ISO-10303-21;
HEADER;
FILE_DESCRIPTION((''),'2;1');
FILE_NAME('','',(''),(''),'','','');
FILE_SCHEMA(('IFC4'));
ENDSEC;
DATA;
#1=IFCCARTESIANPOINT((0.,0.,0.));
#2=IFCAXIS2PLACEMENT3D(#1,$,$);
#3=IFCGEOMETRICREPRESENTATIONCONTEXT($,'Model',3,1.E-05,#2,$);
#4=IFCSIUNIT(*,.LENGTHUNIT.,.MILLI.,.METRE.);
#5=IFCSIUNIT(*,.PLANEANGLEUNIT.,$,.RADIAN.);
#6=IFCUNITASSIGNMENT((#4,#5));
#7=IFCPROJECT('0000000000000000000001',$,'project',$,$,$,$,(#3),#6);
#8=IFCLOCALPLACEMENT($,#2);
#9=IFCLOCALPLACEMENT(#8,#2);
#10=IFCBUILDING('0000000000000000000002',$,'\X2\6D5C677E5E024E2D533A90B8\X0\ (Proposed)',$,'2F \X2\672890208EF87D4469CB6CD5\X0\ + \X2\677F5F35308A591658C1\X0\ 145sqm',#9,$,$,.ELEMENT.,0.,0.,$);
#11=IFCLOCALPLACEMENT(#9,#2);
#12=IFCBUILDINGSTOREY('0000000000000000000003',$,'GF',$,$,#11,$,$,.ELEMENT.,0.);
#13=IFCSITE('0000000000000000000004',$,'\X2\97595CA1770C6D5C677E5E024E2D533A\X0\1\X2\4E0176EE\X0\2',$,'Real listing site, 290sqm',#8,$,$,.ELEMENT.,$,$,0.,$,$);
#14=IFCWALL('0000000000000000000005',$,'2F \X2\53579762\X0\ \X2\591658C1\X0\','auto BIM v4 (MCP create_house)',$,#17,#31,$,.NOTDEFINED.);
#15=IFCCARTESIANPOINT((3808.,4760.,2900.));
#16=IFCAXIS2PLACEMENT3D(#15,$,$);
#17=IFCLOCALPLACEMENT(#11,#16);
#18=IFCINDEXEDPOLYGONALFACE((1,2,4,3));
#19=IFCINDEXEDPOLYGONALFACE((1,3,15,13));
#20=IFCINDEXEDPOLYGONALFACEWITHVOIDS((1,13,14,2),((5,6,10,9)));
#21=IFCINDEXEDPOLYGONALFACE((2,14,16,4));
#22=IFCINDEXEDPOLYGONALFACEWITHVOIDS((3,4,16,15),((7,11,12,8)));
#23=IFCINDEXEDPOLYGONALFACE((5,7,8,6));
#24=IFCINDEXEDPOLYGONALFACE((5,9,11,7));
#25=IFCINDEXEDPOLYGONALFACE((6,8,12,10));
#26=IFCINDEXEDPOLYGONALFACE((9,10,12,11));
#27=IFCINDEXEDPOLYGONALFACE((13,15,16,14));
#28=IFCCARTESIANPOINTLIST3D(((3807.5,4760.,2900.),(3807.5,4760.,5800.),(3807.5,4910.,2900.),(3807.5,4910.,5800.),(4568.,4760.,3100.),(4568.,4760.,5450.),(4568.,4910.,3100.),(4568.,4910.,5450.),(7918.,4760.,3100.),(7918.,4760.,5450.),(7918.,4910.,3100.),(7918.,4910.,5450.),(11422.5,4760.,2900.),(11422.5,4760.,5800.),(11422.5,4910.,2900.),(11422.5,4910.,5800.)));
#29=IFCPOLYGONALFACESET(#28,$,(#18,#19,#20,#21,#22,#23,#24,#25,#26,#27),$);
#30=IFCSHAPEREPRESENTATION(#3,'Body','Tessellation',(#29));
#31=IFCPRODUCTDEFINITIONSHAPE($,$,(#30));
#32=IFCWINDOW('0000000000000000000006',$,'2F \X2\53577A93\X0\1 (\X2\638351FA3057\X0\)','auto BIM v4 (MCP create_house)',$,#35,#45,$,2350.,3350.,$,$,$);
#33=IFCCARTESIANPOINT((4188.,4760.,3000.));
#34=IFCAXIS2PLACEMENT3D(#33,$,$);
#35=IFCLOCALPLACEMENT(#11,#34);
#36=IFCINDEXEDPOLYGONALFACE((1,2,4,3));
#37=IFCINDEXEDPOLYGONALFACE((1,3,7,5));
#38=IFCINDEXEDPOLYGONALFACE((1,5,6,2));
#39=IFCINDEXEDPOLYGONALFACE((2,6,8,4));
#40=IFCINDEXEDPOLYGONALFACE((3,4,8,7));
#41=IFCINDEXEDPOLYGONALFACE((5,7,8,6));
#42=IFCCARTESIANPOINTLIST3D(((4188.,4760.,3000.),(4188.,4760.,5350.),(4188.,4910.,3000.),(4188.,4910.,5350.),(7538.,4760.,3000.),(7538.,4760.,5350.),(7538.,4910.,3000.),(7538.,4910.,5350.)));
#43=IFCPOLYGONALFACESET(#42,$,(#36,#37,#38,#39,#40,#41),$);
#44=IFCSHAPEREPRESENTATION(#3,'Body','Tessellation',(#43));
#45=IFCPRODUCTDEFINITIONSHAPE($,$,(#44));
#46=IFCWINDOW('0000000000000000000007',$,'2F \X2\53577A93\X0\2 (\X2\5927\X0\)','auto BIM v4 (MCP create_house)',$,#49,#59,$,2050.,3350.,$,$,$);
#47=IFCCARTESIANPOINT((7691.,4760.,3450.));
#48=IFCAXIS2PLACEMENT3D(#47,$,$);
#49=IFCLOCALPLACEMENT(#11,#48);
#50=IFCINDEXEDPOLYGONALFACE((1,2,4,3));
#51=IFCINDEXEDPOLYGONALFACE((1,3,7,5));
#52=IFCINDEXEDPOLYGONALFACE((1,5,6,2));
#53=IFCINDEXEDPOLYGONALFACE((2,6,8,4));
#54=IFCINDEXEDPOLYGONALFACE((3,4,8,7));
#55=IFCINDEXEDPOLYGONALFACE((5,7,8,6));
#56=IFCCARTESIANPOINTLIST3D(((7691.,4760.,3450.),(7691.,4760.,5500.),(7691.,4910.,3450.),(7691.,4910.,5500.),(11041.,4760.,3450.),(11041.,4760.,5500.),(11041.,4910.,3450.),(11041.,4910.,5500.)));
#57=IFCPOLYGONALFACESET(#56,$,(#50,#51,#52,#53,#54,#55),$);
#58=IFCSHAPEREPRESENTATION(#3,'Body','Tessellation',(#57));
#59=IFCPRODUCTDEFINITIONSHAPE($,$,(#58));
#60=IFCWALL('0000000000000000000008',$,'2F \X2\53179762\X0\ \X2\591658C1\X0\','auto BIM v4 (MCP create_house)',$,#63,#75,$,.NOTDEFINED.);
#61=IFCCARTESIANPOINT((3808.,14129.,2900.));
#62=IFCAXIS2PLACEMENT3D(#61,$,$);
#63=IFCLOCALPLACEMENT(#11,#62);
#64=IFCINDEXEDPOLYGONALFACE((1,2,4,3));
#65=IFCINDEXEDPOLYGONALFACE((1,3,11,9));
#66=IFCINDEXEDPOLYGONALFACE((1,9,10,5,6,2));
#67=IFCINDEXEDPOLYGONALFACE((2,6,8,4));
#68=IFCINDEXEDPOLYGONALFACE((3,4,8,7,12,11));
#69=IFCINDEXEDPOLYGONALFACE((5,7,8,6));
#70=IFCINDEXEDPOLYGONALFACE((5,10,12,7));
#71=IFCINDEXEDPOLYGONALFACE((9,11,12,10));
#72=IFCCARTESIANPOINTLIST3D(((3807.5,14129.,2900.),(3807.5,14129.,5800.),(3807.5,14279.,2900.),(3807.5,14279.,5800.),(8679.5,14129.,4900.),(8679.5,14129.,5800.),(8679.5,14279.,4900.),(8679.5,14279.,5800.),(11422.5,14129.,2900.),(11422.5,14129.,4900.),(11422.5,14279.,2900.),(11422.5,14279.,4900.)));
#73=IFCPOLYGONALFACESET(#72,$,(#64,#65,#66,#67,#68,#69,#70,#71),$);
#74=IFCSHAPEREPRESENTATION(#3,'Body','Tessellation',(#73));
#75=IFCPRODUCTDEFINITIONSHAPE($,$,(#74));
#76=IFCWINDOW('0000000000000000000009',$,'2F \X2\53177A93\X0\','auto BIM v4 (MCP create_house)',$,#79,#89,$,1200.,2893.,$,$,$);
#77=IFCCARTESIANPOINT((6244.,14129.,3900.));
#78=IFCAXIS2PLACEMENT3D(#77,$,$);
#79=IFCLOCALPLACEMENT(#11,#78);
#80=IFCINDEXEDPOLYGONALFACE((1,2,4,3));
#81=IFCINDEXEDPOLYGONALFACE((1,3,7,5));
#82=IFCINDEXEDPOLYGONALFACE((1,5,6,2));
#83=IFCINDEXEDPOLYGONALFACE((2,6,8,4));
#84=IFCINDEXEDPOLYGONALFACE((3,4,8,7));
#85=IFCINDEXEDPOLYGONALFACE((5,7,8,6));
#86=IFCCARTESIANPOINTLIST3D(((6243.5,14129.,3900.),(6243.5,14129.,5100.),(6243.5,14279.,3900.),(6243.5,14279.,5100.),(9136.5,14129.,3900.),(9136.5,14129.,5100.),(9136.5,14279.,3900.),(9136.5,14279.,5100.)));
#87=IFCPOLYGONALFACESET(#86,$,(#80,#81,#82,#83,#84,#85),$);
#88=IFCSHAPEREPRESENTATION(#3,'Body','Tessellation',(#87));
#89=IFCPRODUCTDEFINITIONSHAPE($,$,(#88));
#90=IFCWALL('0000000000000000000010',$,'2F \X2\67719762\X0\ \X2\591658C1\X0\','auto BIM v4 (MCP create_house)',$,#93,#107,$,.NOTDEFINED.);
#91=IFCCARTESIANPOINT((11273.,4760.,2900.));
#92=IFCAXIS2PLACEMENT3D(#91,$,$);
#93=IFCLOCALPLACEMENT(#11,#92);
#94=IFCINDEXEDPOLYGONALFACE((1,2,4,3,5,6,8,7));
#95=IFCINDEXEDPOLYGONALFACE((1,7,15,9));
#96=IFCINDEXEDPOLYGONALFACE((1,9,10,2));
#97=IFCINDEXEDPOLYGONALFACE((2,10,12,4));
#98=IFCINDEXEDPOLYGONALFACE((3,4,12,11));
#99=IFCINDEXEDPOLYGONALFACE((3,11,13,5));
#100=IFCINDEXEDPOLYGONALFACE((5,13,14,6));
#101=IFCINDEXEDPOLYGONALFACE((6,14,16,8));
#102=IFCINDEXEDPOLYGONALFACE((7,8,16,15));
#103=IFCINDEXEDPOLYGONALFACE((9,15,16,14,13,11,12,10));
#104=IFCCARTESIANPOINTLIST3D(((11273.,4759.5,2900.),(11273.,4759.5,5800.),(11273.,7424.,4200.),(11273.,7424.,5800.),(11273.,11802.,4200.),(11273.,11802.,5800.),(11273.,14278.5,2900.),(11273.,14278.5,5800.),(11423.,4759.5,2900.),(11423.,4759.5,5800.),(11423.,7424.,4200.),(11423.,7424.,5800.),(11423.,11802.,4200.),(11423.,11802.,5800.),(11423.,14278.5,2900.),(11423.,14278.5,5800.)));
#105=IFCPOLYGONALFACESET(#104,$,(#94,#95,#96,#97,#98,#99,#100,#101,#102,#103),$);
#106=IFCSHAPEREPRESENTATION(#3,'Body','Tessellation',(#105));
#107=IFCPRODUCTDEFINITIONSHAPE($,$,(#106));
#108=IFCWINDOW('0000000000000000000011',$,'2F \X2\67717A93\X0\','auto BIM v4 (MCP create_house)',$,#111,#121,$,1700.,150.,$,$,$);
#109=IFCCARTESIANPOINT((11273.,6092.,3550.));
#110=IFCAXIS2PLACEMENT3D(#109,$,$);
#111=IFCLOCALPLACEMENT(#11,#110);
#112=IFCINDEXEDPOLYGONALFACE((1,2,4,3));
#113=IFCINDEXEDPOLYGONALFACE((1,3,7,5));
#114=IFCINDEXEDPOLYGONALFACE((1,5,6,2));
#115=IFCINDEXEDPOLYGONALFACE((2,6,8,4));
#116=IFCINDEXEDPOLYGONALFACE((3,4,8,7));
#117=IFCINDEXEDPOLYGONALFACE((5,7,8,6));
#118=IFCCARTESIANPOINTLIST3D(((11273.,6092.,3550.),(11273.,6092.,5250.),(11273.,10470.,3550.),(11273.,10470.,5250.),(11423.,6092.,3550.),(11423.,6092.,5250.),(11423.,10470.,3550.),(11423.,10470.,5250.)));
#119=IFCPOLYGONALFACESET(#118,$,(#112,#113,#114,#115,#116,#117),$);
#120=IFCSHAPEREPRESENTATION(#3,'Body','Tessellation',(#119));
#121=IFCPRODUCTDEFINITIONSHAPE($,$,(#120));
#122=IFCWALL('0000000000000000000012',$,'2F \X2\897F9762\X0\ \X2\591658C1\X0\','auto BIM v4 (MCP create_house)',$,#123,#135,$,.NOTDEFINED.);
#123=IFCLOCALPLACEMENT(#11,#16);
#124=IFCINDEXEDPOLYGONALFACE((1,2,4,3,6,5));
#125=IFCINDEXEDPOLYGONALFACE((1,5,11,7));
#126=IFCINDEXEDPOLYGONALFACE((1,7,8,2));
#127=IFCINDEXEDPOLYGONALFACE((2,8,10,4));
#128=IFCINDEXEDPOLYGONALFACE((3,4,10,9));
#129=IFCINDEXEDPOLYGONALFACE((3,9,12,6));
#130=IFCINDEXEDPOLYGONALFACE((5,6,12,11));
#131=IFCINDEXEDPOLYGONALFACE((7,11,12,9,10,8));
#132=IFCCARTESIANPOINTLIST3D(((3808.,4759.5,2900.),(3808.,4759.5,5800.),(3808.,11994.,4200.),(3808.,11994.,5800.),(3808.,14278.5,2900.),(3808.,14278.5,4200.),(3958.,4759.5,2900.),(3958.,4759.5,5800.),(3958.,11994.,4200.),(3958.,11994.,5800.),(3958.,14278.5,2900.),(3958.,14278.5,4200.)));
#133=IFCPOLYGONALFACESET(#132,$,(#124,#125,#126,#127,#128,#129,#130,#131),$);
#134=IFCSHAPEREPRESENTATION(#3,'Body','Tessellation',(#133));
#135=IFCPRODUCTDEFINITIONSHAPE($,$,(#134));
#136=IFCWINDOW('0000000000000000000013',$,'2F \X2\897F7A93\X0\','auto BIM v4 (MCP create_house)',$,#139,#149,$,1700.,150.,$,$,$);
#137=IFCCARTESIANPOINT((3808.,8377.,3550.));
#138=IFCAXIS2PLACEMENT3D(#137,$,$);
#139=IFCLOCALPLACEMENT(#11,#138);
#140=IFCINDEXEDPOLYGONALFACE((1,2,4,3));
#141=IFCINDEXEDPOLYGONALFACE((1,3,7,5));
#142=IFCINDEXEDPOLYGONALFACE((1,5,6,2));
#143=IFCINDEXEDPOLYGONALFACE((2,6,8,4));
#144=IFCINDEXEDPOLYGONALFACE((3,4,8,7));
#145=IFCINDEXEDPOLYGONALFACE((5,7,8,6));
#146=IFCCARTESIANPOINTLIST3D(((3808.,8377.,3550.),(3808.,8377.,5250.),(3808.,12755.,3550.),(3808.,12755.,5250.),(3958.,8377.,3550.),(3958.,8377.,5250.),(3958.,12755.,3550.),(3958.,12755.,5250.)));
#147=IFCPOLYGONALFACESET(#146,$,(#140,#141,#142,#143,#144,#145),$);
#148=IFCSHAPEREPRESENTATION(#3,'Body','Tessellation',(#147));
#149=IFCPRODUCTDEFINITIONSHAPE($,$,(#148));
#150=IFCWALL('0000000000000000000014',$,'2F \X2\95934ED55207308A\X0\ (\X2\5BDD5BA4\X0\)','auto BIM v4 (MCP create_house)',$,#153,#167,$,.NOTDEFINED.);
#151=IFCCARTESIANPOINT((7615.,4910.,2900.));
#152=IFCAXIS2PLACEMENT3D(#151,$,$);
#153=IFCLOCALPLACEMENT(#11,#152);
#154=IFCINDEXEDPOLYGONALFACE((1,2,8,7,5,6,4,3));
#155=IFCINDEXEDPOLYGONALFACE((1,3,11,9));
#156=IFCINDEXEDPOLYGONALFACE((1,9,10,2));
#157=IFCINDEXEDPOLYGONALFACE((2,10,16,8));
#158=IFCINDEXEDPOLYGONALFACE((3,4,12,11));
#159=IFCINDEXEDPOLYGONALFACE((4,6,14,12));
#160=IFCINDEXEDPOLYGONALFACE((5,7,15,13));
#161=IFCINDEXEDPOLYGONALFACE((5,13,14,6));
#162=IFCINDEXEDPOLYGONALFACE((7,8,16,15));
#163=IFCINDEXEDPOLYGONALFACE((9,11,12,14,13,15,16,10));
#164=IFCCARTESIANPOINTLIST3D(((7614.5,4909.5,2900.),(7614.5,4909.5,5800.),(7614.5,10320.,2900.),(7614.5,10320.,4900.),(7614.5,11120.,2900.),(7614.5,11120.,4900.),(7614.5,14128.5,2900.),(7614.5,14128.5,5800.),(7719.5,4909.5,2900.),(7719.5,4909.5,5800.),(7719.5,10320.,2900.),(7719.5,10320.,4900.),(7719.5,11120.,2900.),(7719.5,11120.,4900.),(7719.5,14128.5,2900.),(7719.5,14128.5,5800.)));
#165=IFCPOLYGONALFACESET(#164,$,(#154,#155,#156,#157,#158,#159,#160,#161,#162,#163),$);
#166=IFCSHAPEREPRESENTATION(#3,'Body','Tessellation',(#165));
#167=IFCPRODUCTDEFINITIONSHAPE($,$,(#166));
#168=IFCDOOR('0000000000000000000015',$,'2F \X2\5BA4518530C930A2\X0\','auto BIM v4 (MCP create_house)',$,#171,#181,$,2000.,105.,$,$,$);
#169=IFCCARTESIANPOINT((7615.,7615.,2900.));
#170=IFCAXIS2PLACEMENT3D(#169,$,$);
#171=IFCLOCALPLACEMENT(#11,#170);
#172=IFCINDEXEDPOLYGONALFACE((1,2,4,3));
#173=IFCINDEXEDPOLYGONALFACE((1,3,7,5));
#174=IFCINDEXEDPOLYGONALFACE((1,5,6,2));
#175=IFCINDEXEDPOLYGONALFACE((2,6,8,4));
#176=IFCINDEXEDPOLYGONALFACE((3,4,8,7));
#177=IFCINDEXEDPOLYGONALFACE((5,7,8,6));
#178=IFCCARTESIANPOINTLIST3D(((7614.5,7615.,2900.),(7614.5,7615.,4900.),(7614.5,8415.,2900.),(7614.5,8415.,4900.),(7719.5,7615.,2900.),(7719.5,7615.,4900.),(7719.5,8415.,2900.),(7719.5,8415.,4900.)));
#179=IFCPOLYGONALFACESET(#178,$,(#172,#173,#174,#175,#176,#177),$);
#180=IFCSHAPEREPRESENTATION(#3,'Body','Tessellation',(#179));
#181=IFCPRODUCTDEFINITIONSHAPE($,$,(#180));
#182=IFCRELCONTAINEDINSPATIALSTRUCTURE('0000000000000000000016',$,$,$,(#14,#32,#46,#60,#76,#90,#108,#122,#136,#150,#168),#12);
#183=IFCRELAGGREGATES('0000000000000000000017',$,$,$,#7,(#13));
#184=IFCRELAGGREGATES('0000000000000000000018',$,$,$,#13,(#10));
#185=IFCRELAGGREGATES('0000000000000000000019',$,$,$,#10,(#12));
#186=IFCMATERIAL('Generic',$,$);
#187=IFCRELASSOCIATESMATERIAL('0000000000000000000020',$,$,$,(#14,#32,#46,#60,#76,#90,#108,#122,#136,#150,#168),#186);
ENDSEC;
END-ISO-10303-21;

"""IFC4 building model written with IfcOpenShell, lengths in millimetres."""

from ifc_helpers import new_model, si_unit, frame, frame_2d, origin, place, context, project, spatial, rectangle, extrude, material, element, fill, save


model = new_model("IFC4")

# Units and contexts
model_context = context("Model", 3, precision=1e-05, world=origin())
ifc_project = project(units=[si_unit("LENGTHUNIT", "METRE", prefix="MILLI"), si_unit("PLANEANGLEUNIT", "RADIAN")], contexts=[model_context])

# Site, building, storey
site_placement = place(None, origin())
site = spatial("IfcSite", under=ifc_project, at=site_placement, Name="静岡県浜松市中区1丁目2", ObjectType="Real listing site, 290sqm", CompositionType="ELEMENT", RefElevation=0.0)
building_placement = place(site_placement, origin())
building = spatial("IfcBuilding", under=site, at=building_placement, Name="浜松市中区邸 (Proposed)", ObjectType="2F 木造軸組構法 + 板張り外壁 145sqm", CompositionType="ELEMENT", ElevationOfRefHeight=0.0, ElevationOfTerrain=0.0)
storey_placement = place(building_placement, origin())
storey = spatial("IfcBuildingStorey", under=building, at=storey_placement, Name="GF", CompositionType="ELEMENT", Elevation=0.0)

# Shared definitions
ifc_material = material(Name="Generic")

# Wall, openings, windows
wall_1_placement = place(storey_placement, frame((3808.0, 4760.0, 2900.0)))
wall_1 = element("IfcWall", 1, at=wall_1_placement, inside=storey, material=ifc_material, Name="2F 南面 外壁", Description="auto BIM v4 (MCP create_house)", PredefinedType="NOTDEFINED", context=model_context, shape_type="SweptSolid", body=[
    extrude(rectangle(XDim=7615.0, YDim=150.0, at=frame_2d((3807.0, 75.0))), frame((3808.0, 4760.0, 2900.0)), (0.0, 0.0, 1.0), 2900.0),
])
opening_1_placement = place(storey_placement, frame((4188.0, 4760.0, 3000.0)))
opening_1 = element("IfcOpeningElement", 2, at=opening_1_placement, cuts=wall_1, PredefinedType="NOTDEFINED", context=model_context, shape_type="SweptSolid", body=[
    extrude(rectangle(XDim=3350.0, YDim=150.0, at=frame_2d((1675.0, 75.0))), frame((4188.0, 4760.0, 3000.0)), (0.0, 0.0, 1.0), 2350.0),
])
opening_2_placement = place(storey_placement, frame((7691.0, 4760.0, 3450.0)))
opening_2 = element("IfcOpeningElement", 3, at=opening_2_placement, cuts=wall_1, PredefinedType="NOTDEFINED", context=model_context, shape_type="SweptSolid", body=[
    extrude(rectangle(XDim=3350.0, YDim=150.0, at=frame_2d((1675.0, 75.0))), frame((7691.0, 4760.0, 3450.0)), (0.0, 0.0, 1.0), 2050.0),
])
window_1_placement = place(storey_placement, frame((4188.0, 4760.0, 3000.0)))
window_1 = element("IfcWindow", 4, at=window_1_placement, inside=storey, material=ifc_material, Name="2F 南窓1 (掃出し)", Description="auto BIM v4 (MCP create_house)", OverallHeight=2350.0, OverallWidth=3350.0, context=model_context, shape_type="SweptSolid", body=[
    extrude(rectangle(XDim=3350.0, YDim=150.0, at=frame_2d((1675.0, 75.0))), frame((4188.0, 4760.0, 3000.0)), (0.0, 0.0, 1.0), 2350.0),
])
fill(opening_1, window_1)
window_2_placement = place(storey_placement, frame((7691.0, 4760.0, 3450.0)))
window_2 = element("IfcWindow", 5, at=window_2_placement, inside=storey, material=ifc_material, Name="2F 南窓2 (大)", Description="auto BIM v4 (MCP create_house)", OverallHeight=2050.0, OverallWidth=3350.0, context=model_context, shape_type="SweptSolid", body=[
    extrude(rectangle(XDim=3350.0, YDim=150.0, at=frame_2d((1675.0, 75.0))), frame((7691.0, 4760.0, 3450.0)), (0.0, 0.0, 1.0), 2050.0),
])
fill(opening_2, window_2)

# Walls, openings, windows
wall_2_placement = place(storey_placement, frame((3808.0, 14129.0, 2900.0)))
wall_2 = element("IfcWall", 6, at=wall_2_placement, inside=storey, material=ifc_material, Name="2F 北面 外壁", Description="auto BIM v4 (MCP create_house)", PredefinedType="NOTDEFINED", context=model_context, shape_type="SweptSolid", body=[
    extrude(rectangle(XDim=7615.0, YDim=150.0, at=frame_2d((3807.0, 75.0))), frame((3808.0, 14129.0, 2900.0)), (0.0, 0.0, 1.0), 2900.0),
])
opening_3_placement = place(storey_placement, frame((6244.0, 14129.0, 3900.0)))
opening_3 = element("IfcOpeningElement", 7, at=opening_3_placement, cuts=wall_2, PredefinedType="NOTDEFINED", context=model_context, shape_type="SweptSolid", body=[
    extrude(rectangle(XDim=2893.0, YDim=150.0, at=frame_2d((1446.0, 75.0))), frame((6244.0, 14129.0, 3900.0)), (0.0, 0.0, 1.0), 1200.0),
])
window_3_placement = place(storey_placement, frame((6244.0, 14129.0, 3900.0)))
window_3 = element("IfcWindow", 8, at=window_3_placement, inside=storey, material=ifc_material, Name="2F 北窓", Description="auto BIM v4 (MCP create_house)", OverallHeight=1200.0, OverallWidth=2893.0, context=model_context, shape_type="SweptSolid", body=[
    extrude(rectangle(XDim=2893.0, YDim=150.0, at=frame_2d((1446.0, 75.0))), frame((6244.0, 14129.0, 3900.0)), (0.0, 0.0, 1.0), 1200.0),
])
fill(opening_3, window_3)
wall_3_placement = place(storey_placement, frame((11273.0, 4760.0, 2900.0)))
wall_3 = element("IfcWall", 9, at=wall_3_placement, inside=storey, material=ifc_material, Name="2F 東面 外壁", Description="auto BIM v4 (MCP create_house)", PredefinedType="NOTDEFINED", context=model_context, shape_type="SweptSolid", body=[
    extrude(rectangle(XDim=150.0, YDim=9519.0, at=frame_2d((75.0, 4759.0))), frame((11273.0, 4760.0, 2900.0)), (0.0, 0.0, 1.0), 2900.0),
])
opening_4_placement = place(storey_placement, frame((11273.0, 6092.0, 3550.0)))
opening_4 = element("IfcOpeningElement", 10, at=opening_4_placement, cuts=wall_3, PredefinedType="NOTDEFINED", context=model_context, shape_type="SweptSolid", body=[
    extrude(rectangle(XDim=150.0, YDim=4378.0, at=frame_2d((75.0, 2189.0))), frame((11273.0, 6092.0, 3550.0)), (0.0, 0.0, 1.0), 1700.0),
])
window_4_placement = place(storey_placement, frame((11273.0, 6092.0, 3550.0)))
window_4 = element("IfcWindow", 11, at=window_4_placement, inside=storey, material=ifc_material, Name="2F 東窓", Description="auto BIM v4 (MCP create_house)", OverallHeight=1700.0, OverallWidth=150.0, context=model_context, shape_type="SweptSolid", body=[
    extrude(rectangle(XDim=150.0, YDim=4378.0, at=frame_2d((75.0, 2189.0))), frame((11273.0, 6092.0, 3550.0)), (0.0, 0.0, 1.0), 1700.0),
])
fill(opening_4, window_4)
wall_4_placement = place(storey_placement, frame((3808.0, 4760.0, 2900.0)))
wall_4 = element("IfcWall", 12, at=wall_4_placement, inside=storey, material=ifc_material, Name="2F 西面 外壁", Description="auto BIM v4 (MCP create_house)", PredefinedType="NOTDEFINED", context=model_context, shape_type="SweptSolid", body=[
    extrude(rectangle(XDim=150.0, YDim=9519.0, at=frame_2d((75.0, 4759.0))), frame((3808.0, 4760.0, 2900.0)), (0.0, 0.0, 1.0), 2900.0),
])
opening_5_placement = place(storey_placement, frame((3808.0, 8377.0, 3550.0)))
opening_5 = element("IfcOpeningElement", 13, at=opening_5_placement, cuts=wall_4, PredefinedType="NOTDEFINED", context=model_context, shape_type="SweptSolid", body=[
    extrude(rectangle(XDim=150.0, YDim=4378.0, at=frame_2d((75.0, 2189.0))), frame((3808.0, 8377.0, 3550.0)), (0.0, 0.0, 1.0), 1700.0),
])
window_5_placement = place(storey_placement, frame((3808.0, 8377.0, 3550.0)))
window_5 = element("IfcWindow", 14, at=window_5_placement, inside=storey, material=ifc_material, Name="2F 西窓", Description="auto BIM v4 (MCP create_house)", OverallHeight=1700.0, OverallWidth=150.0, context=model_context, shape_type="SweptSolid", body=[
    extrude(rectangle(XDim=150.0, YDim=4378.0, at=frame_2d((75.0, 2189.0))), frame((3808.0, 8377.0, 3550.0)), (0.0, 0.0, 1.0), 1700.0),
])
fill(opening_5, window_5)

# Wall, opening, door
wall_5_placement = place(storey_placement, frame((7615.0, 4910.0, 2900.0)))
wall_5 = element("IfcWall", 15, at=wall_5_placement, inside=storey, material=ifc_material, Name="2F 間仕切り (寝室)", Description="auto BIM v4 (MCP create_house)", PredefinedType="NOTDEFINED", context=model_context, shape_type="SweptSolid", body=[
    extrude(rectangle(XDim=105.0, YDim=9219.0, at=frame_2d((52.0, 4609.0))), frame((7615.0, 4910.0, 2900.0)), (0.0, 0.0, 1.0), 2900.0),
])
opening_6_placement = place(storey_placement, frame((7615.0, 7615.0, 2900.0)))
opening_6 = element("IfcOpeningElement", 16, at=opening_6_placement, cuts=wall_5, PredefinedType="NOTDEFINED", context=model_context, shape_type="SweptSolid", body=[
    extrude(rectangle(XDim=105.0, YDim=800.0, at=frame_2d((52.0, 400.0))), frame((7615.0, 7615.0, 2900.0)), (0.0, 0.0, 1.0), 2000.0),
])
door_1_placement = place(storey_placement, frame((7615.0, 7615.0, 2900.0)))
door_1 = element("IfcDoor", 17, at=door_1_placement, inside=storey, material=ifc_material, Name="2F 室内ドア", Description="auto BIM v4 (MCP create_house)", OverallHeight=2000.0, OverallWidth=105.0, context=model_context, shape_type="SweptSolid", body=[
    extrude(rectangle(XDim=105.0, YDim=800.0, at=frame_2d((52.0, 400.0))), frame((7615.0, 7615.0, 2900.0)), (0.0, 0.0, 1.0), 2000.0),
])
fill(opening_6, door_1)

save(model, "model.ifc")
